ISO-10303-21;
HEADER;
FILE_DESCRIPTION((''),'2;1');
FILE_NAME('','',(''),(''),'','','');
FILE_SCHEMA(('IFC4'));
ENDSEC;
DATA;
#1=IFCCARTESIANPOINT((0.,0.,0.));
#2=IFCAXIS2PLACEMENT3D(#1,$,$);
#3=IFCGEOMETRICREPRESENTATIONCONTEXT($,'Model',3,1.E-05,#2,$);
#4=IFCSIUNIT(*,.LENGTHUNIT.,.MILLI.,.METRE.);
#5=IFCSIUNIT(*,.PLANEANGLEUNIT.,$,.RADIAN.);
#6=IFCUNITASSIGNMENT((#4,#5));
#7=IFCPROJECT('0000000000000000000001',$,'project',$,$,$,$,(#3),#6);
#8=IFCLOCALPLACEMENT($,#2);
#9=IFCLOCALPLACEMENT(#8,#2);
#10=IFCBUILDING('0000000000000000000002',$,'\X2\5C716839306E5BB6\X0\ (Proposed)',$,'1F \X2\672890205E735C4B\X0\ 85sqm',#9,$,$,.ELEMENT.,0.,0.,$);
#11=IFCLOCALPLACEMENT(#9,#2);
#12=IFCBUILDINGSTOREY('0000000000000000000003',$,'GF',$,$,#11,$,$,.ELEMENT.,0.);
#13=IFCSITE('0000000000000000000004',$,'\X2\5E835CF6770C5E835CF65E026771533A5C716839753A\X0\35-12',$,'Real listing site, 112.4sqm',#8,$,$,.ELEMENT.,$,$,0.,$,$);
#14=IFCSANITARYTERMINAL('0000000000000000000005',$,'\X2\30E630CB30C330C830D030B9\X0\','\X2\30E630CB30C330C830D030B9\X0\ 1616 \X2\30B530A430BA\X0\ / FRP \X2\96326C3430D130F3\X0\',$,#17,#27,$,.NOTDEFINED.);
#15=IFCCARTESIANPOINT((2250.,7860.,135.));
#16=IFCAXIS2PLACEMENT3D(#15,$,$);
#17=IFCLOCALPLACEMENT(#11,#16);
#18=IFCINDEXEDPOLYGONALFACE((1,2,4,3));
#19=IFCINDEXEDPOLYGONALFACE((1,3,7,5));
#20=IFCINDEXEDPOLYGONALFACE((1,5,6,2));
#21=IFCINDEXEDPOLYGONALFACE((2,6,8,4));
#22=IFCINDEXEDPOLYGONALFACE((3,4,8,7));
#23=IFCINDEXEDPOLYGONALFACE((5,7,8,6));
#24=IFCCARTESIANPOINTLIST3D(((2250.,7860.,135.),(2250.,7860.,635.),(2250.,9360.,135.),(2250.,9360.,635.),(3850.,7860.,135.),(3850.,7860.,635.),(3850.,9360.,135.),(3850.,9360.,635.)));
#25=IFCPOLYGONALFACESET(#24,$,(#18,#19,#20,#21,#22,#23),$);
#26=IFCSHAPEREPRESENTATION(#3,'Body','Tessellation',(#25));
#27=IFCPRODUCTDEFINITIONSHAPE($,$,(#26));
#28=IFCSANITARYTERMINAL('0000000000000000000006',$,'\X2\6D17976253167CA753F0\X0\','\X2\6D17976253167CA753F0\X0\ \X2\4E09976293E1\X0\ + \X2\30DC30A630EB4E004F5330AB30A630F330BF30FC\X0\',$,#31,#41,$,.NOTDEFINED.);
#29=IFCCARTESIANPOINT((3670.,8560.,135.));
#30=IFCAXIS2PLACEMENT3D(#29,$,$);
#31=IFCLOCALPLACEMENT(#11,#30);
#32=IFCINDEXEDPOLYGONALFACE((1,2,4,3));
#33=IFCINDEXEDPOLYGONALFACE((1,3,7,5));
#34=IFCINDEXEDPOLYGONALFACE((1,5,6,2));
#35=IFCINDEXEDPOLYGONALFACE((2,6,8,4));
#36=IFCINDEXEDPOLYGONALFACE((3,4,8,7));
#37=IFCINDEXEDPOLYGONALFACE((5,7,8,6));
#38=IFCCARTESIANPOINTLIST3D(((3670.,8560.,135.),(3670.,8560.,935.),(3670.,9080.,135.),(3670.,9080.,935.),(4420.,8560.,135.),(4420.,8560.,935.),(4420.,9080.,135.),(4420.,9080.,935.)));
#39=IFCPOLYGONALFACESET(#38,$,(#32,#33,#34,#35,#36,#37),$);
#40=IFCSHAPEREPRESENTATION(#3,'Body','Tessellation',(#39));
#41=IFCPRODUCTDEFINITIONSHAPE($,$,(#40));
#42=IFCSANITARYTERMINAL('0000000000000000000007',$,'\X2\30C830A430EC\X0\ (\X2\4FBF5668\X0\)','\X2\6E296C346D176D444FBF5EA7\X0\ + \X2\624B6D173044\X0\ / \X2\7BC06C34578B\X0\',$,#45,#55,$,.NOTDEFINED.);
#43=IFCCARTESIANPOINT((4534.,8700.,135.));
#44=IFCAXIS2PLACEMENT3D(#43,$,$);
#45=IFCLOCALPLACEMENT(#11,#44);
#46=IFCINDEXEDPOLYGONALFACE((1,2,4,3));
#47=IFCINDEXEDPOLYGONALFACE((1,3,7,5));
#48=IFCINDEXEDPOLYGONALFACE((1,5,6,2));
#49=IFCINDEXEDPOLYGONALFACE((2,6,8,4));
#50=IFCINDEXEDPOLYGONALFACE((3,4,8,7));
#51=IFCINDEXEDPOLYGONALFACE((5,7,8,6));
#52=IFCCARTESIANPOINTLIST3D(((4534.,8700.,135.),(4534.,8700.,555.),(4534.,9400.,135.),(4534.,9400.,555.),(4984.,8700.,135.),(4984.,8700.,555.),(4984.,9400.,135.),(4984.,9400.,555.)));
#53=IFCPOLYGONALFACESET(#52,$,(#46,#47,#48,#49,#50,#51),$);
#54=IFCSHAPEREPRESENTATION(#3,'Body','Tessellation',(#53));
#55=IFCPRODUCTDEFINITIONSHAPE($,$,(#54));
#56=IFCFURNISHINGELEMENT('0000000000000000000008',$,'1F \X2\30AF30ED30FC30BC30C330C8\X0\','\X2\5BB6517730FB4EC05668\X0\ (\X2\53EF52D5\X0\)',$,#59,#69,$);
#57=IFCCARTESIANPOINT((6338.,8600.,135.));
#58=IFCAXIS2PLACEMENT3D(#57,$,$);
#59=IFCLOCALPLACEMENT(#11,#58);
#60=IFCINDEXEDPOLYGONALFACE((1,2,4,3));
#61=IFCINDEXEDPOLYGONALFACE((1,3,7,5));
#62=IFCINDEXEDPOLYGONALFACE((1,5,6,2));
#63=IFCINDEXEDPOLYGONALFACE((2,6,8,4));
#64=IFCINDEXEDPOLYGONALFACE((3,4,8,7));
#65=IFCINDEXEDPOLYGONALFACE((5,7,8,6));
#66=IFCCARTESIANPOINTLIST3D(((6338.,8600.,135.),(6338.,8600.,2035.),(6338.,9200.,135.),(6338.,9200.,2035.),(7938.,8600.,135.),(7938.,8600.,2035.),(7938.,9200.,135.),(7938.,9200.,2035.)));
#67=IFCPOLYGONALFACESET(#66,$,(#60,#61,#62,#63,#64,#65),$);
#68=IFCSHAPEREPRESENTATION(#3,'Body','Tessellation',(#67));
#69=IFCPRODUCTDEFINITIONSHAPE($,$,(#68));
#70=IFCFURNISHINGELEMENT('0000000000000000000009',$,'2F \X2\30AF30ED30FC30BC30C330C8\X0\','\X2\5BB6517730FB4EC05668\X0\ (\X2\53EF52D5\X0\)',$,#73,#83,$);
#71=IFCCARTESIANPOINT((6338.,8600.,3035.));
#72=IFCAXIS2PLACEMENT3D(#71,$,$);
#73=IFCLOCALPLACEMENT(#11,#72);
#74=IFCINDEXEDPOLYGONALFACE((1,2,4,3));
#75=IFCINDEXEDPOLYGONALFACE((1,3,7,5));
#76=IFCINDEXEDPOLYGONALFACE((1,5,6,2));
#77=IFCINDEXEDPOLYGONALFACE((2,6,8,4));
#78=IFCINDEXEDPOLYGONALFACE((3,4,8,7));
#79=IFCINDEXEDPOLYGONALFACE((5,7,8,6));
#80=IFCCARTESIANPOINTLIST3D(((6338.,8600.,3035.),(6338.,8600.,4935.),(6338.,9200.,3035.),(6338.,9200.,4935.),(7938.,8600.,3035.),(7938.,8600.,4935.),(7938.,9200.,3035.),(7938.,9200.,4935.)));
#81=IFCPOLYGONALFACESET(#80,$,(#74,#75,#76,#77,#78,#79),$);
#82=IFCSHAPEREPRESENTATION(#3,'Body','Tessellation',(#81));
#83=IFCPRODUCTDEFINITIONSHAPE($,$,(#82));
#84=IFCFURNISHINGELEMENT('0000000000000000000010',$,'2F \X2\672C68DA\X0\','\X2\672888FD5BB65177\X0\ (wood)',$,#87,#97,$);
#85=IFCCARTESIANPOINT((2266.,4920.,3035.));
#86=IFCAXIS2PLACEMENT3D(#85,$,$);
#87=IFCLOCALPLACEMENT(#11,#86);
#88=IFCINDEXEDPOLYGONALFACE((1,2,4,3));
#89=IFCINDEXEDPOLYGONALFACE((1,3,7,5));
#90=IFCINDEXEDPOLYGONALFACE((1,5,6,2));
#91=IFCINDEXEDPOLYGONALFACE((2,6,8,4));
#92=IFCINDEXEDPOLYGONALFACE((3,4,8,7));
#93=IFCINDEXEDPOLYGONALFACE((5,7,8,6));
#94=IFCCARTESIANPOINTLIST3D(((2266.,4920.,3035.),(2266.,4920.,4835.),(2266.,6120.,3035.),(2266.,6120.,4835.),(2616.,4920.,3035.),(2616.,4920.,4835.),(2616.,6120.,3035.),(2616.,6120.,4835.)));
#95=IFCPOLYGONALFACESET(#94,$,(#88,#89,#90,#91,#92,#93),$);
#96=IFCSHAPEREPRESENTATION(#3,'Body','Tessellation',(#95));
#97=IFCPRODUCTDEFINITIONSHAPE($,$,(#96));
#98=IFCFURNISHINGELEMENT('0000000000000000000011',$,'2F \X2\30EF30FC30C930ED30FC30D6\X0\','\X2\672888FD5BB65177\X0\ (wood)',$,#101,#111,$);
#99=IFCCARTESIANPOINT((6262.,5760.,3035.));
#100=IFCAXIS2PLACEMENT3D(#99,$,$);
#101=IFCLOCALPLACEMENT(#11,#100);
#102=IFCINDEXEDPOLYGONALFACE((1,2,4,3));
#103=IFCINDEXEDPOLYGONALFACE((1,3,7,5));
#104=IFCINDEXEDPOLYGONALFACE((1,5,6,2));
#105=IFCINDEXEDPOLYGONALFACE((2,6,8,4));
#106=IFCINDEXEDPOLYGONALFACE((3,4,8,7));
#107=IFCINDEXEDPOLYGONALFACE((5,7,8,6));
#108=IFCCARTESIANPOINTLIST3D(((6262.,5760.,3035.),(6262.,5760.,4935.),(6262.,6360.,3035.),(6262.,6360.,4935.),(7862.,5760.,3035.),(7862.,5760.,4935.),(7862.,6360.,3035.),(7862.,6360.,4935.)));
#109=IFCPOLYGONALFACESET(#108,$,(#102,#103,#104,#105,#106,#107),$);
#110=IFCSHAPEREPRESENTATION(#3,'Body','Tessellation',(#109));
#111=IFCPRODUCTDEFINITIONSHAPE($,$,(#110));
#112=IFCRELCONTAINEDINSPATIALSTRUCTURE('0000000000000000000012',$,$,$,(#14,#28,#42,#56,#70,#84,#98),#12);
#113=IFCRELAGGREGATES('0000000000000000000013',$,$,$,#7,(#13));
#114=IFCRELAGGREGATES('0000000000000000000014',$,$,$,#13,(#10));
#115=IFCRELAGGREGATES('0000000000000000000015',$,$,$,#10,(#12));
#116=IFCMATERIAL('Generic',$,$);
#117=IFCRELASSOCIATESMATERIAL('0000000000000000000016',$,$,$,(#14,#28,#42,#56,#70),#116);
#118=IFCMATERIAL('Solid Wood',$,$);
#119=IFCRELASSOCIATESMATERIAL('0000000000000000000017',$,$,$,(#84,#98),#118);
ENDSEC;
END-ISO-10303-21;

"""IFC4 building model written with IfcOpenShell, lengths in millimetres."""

from ifc_helpers import new_model, si_unit, frame, frame_2d, origin, place, context, project, spatial, rectangle, extrude, material, element, save


model = new_model("IFC4")

# Units and contexts
model_context = context("Model", 3, precision=1e-05, world=origin())
ifc_project = project(units=[si_unit("LENGTHUNIT", "METRE", prefix="MILLI"), si_unit("PLANEANGLEUNIT", "RADIAN")], contexts=[model_context])

# Site, building, storey
site_placement = place(None, origin())
site = spatial("IfcSite", under=ifc_project, at=site_placement, Name="広島県広島市東区山根町35-12", ObjectType="Real listing site, 112.4sqm", CompositionType="ELEMENT", RefElevation=0.0)
building_placement = place(site_placement, origin())
building = spatial("IfcBuilding", under=site, at=building_placement, Name="山根の家 (Proposed)", ObjectType="1F 木造平屋 85sqm", CompositionType="ELEMENT", ElevationOfRefHeight=0.0, ElevationOfTerrain=0.0)
storey_placement = place(building_placement, origin())
storey = spatial("IfcBuildingStorey", under=building, at=storey_placement, Name="GF", CompositionType="ELEMENT", Elevation=0.0)

# Shared definitions
ifc_material_1 = material(Name="Solid Wood")

# Shared definitions
ifc_material_2 = material(Name="Generic")

# Sanitary terminals
sanitary_terminal_1_placement = place(storey_placement, frame((2250.0, 7860.0, 135.0)))
element("IfcSanitaryTerminal", 1, at=sanitary_terminal_1_placement, inside=storey, material=ifc_material_2, Name="ユニットバス", Description="ユニットバス 1616 サイズ / FRP 防水パン", PredefinedType="NOTDEFINED", context=model_context, shape_type="SweptSolid", body=[
    extrude(rectangle(XDim=1600.0, YDim=1500.0, at=frame_2d((800.0, 750.0))), frame((2250.0, 7860.0, 135.0)), (0.0, 0.0, 1.0), 500.0),
])
sanitary_terminal_2_placement = place(storey_placement, frame((3670.0, 8560.0, 135.0)))
element("IfcSanitaryTerminal", 2, at=sanitary_terminal_2_placement, inside=storey, material=ifc_material_2, Name="洗面化粧台", Description="洗面化粧台 三面鏡 + ボウル一体カウンター", PredefinedType="NOTDEFINED", context=model_context, shape_type="SweptSolid", body=[
    extrude(rectangle(XDim=750.0, YDim=520.0, at=frame_2d((375.0, 260.0))), frame((3670.0, 8560.0, 135.0)), (0.0, 0.0, 1.0), 800.0),
])
sanitary_terminal_3_placement = place(storey_placement, frame((4534.0, 8700.0, 135.0)))
element("IfcSanitaryTerminal", 3, at=sanitary_terminal_3_placement, inside=storey, material=ifc_material_2, Name="トイレ (便器)", Description="温水洗浄便座 + 手洗い / 節水型", PredefinedType="NOTDEFINED", context=model_context, shape_type="SweptSolid", body=[
    extrude(rectangle(XDim=450.0, YDim=700.0, at=frame_2d((225.0, 350.0))), frame((4534.0, 8700.0, 135.0)), (0.0, 0.0, 1.0), 420.0),
])

# Furnishing elements
furnishing_1_placement = place(storey_placement, frame((6338.0, 8600.0, 135.0)))
element("IfcFurnishingElement", 4, at=furnishing_1_placement, inside=storey, material=ifc_material_2, Name="1F クローゼット", Description="家具・什器 (可動)", context=model_context, shape_type="SweptSolid", body=[
    extrude(rectangle(XDim=1600.0, YDim=600.0, at=frame_2d((800.0, 300.0))), frame((6338.0, 8600.0, 135.0)), (0.0, 0.0, 1.0), 1900.0),
])
furnishing_2_placement = place(storey_placement, frame((6338.0, 8600.0, 3035.0)))
element("IfcFurnishingElement", 5, at=furnishing_2_placement, inside=storey, material=ifc_material_2, Name="2F クローゼット", Description="家具・什器 (可動)", context=model_context, shape_type="SweptSolid", body=[
    extrude(rectangle(XDim=1600.0, YDim=600.0, at=frame_2d((800.0, 300.0))), frame((6338.0, 8600.0, 3035.0)), (0.0, 0.0, 1.0), 1900.0),
])
furnishing_3_placement = place(storey_placement, frame((2266.0, 4920.0, 3035.0)))
element("IfcFurnishingElement", 6, at=furnishing_3_placement, inside=storey, material=ifc_material_1, Name="2F 本棚", Description="木製家具 (wood)", context=model_context, shape_type="SweptSolid", body=[
    extrude(rectangle(XDim=350.0, YDim=1200.0, at=frame_2d((175.0, 600.0))), frame((2266.0, 4920.0, 3035.0)), (0.0, 0.0, 1.0), 1800.0),
])
furnishing_4_placement = place(storey_placement, frame((6262.0, 5760.0, 3035.0)))
element("IfcFurnishingElement", 7, at=furnishing_4_placement, inside=storey, material=ifc_material_1, Name="2F ワードローブ", Description="木製家具 (wood)", context=model_context, shape_type="SweptSolid", body=[
    extrude(rectangle(XDim=1600.0, YDim=600.0, at=frame_2d((800.0, 300.0))), frame((6262.0, 5760.0, 3035.0)), (0.0, 0.0, 1.0), 1900.0),
])

save(model, "model.ifc")
